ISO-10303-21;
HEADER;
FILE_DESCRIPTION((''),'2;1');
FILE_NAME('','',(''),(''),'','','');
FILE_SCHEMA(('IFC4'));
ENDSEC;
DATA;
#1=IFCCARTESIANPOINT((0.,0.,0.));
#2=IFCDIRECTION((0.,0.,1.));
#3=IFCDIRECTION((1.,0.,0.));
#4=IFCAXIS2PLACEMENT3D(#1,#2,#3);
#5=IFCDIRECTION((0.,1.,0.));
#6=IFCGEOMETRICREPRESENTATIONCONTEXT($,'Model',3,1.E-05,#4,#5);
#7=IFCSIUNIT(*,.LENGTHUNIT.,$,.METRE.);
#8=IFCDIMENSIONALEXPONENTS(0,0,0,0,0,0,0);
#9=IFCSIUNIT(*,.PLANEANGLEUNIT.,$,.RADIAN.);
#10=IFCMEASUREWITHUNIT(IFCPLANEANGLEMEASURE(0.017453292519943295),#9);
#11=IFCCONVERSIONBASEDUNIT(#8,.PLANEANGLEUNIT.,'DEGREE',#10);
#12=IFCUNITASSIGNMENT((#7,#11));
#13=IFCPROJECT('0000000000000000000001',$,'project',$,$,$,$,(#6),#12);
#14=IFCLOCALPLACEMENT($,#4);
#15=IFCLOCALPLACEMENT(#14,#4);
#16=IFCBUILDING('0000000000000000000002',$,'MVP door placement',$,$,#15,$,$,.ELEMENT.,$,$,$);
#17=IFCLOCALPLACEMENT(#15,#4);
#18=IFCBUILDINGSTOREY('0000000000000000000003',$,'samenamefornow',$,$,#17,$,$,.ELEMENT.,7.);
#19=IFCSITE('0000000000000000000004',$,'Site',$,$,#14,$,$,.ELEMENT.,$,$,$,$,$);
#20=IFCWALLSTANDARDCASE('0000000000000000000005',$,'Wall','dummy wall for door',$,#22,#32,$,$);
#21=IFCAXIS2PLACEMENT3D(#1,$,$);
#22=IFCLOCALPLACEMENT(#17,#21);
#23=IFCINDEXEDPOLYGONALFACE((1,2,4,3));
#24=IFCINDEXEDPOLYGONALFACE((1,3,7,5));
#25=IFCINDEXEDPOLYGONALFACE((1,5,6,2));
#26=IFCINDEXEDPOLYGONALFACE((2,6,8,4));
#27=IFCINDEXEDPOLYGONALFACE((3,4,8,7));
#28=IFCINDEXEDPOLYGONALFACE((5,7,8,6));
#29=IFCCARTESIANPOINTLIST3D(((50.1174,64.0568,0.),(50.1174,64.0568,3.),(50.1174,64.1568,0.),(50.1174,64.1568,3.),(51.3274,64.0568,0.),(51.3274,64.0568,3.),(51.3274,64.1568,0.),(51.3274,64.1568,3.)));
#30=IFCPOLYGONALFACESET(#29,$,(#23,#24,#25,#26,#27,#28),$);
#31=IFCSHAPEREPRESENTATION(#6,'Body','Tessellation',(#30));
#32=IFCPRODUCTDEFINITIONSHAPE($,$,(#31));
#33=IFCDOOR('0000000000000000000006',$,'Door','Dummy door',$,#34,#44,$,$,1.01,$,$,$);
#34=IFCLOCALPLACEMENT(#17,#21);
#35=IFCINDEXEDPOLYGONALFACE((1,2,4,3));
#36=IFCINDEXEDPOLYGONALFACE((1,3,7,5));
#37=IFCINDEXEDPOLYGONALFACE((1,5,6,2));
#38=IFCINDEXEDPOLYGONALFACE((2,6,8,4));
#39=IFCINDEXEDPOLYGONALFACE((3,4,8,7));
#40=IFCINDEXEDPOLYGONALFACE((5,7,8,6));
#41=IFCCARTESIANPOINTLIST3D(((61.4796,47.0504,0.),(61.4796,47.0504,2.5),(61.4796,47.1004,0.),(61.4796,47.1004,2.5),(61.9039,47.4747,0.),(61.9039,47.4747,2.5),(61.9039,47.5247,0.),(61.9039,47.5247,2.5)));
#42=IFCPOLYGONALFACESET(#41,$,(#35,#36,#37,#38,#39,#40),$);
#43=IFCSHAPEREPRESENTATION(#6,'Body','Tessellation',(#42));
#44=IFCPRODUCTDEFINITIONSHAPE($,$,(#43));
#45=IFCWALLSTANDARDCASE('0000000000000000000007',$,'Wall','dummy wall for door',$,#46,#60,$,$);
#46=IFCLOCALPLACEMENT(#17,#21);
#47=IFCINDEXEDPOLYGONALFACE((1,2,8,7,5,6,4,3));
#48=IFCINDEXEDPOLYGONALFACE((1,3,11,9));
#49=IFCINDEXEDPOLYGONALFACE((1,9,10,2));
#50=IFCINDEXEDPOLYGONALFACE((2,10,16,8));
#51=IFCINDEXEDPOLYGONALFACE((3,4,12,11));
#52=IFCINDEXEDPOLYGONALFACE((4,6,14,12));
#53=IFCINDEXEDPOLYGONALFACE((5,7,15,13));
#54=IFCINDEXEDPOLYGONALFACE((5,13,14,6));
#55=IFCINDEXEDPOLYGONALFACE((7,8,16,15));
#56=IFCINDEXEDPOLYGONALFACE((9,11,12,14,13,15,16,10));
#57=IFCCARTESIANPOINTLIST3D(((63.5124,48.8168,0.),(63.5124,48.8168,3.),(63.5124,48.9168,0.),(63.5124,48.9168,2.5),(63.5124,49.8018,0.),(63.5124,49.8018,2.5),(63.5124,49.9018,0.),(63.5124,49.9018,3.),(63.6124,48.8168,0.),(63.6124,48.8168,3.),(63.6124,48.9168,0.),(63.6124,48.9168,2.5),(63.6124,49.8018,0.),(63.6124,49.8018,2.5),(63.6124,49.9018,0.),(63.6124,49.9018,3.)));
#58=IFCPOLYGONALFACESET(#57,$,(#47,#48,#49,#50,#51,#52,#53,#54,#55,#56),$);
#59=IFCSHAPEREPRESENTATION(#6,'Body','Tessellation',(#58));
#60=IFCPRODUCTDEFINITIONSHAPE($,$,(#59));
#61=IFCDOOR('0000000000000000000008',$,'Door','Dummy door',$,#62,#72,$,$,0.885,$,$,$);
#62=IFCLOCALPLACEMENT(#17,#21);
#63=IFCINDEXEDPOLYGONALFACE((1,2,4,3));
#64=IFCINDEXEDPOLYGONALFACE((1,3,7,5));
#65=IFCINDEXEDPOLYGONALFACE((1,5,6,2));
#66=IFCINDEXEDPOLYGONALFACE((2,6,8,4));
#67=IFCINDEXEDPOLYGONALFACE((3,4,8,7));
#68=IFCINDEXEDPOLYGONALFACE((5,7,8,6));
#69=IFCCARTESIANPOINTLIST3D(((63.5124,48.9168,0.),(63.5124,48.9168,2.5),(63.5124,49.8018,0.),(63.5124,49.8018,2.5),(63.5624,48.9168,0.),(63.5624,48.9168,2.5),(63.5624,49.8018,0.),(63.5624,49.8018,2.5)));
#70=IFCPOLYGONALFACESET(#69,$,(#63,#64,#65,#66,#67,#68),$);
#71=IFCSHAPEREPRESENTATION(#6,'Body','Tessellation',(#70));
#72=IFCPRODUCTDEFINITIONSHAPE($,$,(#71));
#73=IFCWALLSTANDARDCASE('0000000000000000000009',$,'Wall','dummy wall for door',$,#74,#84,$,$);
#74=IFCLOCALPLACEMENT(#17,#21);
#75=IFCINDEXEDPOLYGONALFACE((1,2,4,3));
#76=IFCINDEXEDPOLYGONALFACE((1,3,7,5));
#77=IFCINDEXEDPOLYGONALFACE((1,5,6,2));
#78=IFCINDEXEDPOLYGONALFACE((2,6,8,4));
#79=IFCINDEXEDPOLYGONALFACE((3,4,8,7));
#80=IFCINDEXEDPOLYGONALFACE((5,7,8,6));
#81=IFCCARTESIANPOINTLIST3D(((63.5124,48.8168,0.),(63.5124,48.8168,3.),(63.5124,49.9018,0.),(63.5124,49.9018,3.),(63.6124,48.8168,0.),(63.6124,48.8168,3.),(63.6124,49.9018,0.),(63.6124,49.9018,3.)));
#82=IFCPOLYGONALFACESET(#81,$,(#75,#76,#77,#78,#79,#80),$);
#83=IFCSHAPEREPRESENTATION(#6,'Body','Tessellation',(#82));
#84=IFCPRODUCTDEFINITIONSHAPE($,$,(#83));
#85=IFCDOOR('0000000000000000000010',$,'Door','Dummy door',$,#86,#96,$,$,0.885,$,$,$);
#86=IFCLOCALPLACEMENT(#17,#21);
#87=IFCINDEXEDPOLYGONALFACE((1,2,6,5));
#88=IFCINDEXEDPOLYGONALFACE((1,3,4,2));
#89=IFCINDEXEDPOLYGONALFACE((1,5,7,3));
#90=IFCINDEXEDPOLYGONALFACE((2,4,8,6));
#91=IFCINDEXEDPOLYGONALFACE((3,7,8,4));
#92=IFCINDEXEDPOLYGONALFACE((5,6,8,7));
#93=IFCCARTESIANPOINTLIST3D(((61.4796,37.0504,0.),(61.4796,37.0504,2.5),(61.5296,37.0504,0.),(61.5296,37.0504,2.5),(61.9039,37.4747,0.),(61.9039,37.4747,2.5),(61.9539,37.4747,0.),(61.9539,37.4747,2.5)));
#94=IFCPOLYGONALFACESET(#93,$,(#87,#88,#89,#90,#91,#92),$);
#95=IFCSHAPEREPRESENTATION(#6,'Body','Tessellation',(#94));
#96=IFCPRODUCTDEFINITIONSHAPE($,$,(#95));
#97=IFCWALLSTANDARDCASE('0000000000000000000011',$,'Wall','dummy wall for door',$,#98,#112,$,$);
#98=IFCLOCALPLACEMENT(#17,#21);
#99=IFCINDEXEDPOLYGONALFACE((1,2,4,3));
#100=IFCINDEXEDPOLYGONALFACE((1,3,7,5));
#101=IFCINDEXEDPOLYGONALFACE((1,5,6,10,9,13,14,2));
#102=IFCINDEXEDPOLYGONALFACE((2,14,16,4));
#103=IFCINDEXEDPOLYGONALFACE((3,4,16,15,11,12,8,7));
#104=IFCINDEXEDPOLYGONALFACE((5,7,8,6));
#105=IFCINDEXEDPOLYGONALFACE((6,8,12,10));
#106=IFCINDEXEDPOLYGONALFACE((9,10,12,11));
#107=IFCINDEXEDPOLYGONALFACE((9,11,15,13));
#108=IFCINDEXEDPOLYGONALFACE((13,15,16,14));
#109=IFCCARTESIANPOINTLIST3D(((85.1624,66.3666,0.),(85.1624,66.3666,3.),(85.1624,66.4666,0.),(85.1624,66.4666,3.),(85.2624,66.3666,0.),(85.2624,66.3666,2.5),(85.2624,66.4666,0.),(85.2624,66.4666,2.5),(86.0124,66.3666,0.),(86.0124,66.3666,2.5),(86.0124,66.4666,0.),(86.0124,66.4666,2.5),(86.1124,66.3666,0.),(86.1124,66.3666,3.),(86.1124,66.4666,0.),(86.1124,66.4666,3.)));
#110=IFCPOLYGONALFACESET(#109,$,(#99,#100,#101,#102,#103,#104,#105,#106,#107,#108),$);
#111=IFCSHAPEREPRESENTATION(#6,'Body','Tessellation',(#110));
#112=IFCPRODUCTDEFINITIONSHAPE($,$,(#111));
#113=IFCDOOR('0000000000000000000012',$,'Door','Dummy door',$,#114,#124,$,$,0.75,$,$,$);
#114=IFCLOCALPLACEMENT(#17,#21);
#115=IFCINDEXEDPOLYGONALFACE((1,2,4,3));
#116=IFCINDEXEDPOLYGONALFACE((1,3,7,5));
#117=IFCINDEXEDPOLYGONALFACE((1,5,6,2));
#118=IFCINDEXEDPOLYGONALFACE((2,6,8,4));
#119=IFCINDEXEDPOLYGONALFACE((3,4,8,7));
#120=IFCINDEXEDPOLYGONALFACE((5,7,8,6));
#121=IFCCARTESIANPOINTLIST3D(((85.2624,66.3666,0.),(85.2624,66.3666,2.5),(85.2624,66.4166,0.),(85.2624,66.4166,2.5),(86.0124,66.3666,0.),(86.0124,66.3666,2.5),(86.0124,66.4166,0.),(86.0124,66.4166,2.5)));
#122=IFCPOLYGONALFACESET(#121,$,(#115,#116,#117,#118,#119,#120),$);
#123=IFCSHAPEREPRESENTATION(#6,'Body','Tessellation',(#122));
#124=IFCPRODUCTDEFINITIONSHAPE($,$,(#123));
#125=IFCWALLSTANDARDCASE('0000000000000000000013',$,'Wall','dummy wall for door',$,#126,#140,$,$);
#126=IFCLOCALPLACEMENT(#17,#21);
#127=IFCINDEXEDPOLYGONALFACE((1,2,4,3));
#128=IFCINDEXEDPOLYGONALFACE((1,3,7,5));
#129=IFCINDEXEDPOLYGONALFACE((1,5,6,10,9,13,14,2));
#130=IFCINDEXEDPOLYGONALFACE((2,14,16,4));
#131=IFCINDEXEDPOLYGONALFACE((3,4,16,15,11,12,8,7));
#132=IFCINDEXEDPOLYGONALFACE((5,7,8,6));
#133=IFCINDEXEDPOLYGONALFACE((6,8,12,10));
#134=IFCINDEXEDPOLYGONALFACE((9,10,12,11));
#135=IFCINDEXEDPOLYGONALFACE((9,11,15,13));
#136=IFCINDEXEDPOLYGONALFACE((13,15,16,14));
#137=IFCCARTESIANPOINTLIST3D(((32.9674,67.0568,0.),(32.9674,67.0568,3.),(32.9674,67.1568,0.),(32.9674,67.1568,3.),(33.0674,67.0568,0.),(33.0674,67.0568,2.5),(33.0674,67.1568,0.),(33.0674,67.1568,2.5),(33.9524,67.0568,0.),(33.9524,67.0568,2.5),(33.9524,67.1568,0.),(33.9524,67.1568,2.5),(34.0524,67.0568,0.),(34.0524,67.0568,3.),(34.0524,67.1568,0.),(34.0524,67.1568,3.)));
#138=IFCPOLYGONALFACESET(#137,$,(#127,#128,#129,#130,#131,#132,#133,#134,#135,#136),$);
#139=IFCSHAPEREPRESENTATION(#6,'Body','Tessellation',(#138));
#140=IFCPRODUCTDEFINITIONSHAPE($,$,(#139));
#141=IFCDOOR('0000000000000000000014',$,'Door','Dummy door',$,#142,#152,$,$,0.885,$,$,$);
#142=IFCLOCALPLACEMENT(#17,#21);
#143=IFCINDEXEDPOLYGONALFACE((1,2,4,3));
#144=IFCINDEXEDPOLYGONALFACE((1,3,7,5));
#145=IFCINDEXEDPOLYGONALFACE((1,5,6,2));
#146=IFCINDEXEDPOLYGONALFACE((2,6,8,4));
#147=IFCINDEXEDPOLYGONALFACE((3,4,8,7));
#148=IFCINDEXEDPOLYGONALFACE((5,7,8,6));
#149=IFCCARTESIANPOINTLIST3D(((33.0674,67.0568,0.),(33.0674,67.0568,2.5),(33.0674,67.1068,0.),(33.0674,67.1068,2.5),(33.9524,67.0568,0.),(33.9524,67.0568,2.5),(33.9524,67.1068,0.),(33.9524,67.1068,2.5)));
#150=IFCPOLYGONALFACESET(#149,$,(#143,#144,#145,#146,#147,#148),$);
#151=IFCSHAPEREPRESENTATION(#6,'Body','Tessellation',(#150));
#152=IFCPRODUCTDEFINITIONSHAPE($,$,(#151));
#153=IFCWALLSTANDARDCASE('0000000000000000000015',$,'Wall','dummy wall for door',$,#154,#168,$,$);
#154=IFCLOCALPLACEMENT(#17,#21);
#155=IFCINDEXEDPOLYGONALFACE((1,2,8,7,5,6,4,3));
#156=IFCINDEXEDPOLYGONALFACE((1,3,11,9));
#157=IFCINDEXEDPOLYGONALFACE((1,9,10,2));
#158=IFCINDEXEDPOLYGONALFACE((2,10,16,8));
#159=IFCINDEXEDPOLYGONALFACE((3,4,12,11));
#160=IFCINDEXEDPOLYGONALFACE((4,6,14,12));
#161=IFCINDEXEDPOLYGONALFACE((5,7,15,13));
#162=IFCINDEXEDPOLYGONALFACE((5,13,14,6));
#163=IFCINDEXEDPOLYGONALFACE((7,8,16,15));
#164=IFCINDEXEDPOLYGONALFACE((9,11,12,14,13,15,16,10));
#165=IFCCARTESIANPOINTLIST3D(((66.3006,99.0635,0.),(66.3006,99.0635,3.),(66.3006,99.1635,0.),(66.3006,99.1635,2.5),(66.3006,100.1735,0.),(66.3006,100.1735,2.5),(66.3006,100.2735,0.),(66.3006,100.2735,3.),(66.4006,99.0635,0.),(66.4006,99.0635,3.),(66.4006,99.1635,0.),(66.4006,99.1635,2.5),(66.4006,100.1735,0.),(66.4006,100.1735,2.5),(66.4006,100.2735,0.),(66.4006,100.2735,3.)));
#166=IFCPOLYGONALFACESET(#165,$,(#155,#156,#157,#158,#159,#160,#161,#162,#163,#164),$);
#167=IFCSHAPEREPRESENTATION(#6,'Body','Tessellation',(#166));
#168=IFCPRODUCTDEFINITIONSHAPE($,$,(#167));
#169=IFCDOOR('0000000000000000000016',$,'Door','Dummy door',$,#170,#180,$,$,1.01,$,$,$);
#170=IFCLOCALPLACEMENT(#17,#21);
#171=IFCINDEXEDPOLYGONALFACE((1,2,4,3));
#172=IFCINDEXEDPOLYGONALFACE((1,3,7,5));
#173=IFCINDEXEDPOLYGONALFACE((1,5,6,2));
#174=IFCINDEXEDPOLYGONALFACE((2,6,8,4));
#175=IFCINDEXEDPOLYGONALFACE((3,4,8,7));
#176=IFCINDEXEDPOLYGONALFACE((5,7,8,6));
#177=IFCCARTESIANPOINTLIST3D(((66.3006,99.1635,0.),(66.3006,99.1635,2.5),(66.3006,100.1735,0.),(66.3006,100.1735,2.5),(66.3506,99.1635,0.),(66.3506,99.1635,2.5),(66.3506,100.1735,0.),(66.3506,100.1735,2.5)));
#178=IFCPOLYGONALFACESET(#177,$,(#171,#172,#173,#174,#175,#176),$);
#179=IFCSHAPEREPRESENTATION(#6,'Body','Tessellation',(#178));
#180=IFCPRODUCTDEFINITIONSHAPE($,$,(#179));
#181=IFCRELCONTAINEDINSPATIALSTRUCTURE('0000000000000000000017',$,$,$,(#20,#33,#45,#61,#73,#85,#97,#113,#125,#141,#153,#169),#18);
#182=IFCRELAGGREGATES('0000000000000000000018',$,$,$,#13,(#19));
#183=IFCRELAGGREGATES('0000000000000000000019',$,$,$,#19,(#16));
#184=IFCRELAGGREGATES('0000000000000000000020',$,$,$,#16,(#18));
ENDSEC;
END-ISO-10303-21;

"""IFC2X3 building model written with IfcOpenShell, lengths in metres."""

from ifc_helpers import new_model, entity, si_unit, converted_unit, direction, origin_with_axes, place, context, project, spatial, polyline, outline, extrude, element, fill, save


model = new_model("IFC2X3")

# Units and contexts
model_context = context("Model", 3, precision=1e-05, world=origin_with_axes(), true_north=direction((0.0, 1.0, 0.0)))
ifc_project = project(units=[si_unit("LENGTHUNIT", "METRE"), converted_unit("PLANEANGLEUNIT", "DEGREE", entity("IfcPlaneAngleMeasure", 0.017453292519943295), si_unit("PLANEANGLEUNIT", "RADIAN"), dimensions=[0, 0, 0, 0, 0, 0, 0])], contexts=[model_context])

# Site, building, storey
site_placement = place(None, origin_with_axes())
site = spatial("IfcSite", under=ifc_project, at=site_placement, Name="Site", CompositionType="ELEMENT")
building_placement = place(site_placement, origin_with_axes())
building = spatial("IfcBuilding", under=site, at=building_placement, Name="MVP door placement", CompositionType="ELEMENT")
storey_placement = place(building_placement, origin_with_axes())
storey = spatial("IfcBuildingStorey", under=building, at=storey_placement, Name="samenamefornow", CompositionType="ELEMENT", Elevation=7.0)

# Walls, openings, doors
wall_1_placement = place(storey_placement, origin_with_axes())
wall_1 = element("IfcWallStandardCase", 1, at=wall_1_placement, inside=storey, Name="Wall", Description="dummy wall for door", context=model_context, shape_type="SweptSolid", body=[
    extrude(outline(polyline([(51.3274, 64.0568, 0.0), (50.1174, 64.0568, 0.0), (50.1174, 64.1568, 0.0), (51.3274, 64.1568, 0.0), (51.3274, 64.0568, 0.0)])), origin_with_axes(), (0.0, 0.0, 1.0), 3.0),
])
opening_1_placement = place(wall_1_placement, origin_with_axes())
opening_1 = element("IfcOpeningElement", 2, at=opening_1_placement, cuts=wall_1, context=model_context, shape_type="SweptSolid", body=[
    extrude(outline(polyline([(61.4796, 47.0504, 0.0), (61.9039, 47.4747, 0.0), (61.9039, 47.5747, 0.0), (61.4796, 47.1504, 0.0), (61.4796, 47.0504, 0.0)])), origin_with_axes(), (0.0, 0.0, 1.0), 2.5),
])
door_1_placement = place(opening_1_placement, origin_with_axes())
door_1 = element("IfcDoor", 3, at=door_1_placement, inside=storey, Name="Door", Description="Dummy door", OverallWidth=1.01, context=model_context, shape_type="SweptSolid", body=[
    extrude(outline(polyline([(61.4796, 47.0504, 0.0), (61.9039, 47.4747, 0.0), (61.9039, 47.5247, 0.0), (61.4796, 47.1004, 0.0), (61.4796, 47.0504, 0.0)])), origin_with_axes(), (0.0, 0.0, 1.0), 2.5),
])
fill(opening_1, door_1)
wall_2_placement = place(storey_placement, origin_with_axes())
wall_2 = element("IfcWallStandardCase", 4, at=wall_2_placement, inside=storey, Name="Wall", Description="dummy wall for door", context=model_context, shape_type="SweptSolid", body=[
    extrude(outline(polyline([(63.5124, 49.9018, 0.0), (63.5124, 48.8168, 0.0), (63.6124, 48.8168, 0.0), (63.6124, 49.9018, 0.0), (63.5124, 49.9018, 0.0)])), origin_with_axes(), (0.0, 0.0, 1.0), 3.0),
])
opening_2_placement = place(wall_2_placement, origin_with_axes())
opening_2 = element("IfcOpeningElement", 5, at=opening_2_placement, cuts=wall_2, context=model_context, shape_type="SweptSolid", body=[
    extrude(outline(polyline([(63.5124, 49.8018, 0.0), (63.5124, 48.9168, 0.0), (63.6124, 48.9168, 0.0), (63.6124, 49.8018, 0.0), (63.5124, 49.8018, 0.0)])), origin_with_axes(), (0.0, 0.0, 1.0), 2.5),
])
door_2_placement = place(opening_2_placement, origin_with_axes())
door_2 = element("IfcDoor", 6, at=door_2_placement, inside=storey, Name="Door", Description="Dummy door", OverallWidth=0.885, context=model_context, shape_type="SweptSolid", body=[
    extrude(outline(polyline([(63.5124, 49.8018, 0.0), (63.5124, 48.9168, 0.0), (63.5624, 48.9168, 0.0), (63.5624, 49.8018, 0.0), (63.5124, 49.8018, 0.0)])), origin_with_axes(), (0.0, 0.0, 1.0), 2.5),
])
fill(opening_2, door_2)
wall_3_placement = place(storey_placement, origin_with_axes())
wall_3 = element("IfcWallStandardCase", 7, at=wall_3_placement, inside=storey, Name="Wall", Description="dummy wall for door", context=model_context, shape_type="SweptSolid", body=[
    extrude(outline(polyline([(63.5124, 49.9018, 0.0), (63.5124, 48.8168, 0.0), (63.6124, 48.8168, 0.0), (63.6124, 49.9018, 0.0), (63.5124, 49.9018, 0.0)])), origin_with_axes(), (0.0, 0.0, 1.0), 3.0),
])
opening_3_placement = place(wall_3_placement, origin_with_axes())
opening_3 = element("IfcOpeningElement", 8, at=opening_3_placement, cuts=wall_3, context=model_context, shape_type="SweptSolid", body=[
    extrude(outline(polyline([(61.4796, 37.0504, 0.0), (61.9039, 37.4747, 0.0), (62.0039, 37.4747, 0.0), (61.5796, 37.0504, 0.0), (61.4796, 37.0504, 0.0)])), origin_with_axes(), (0.0, 0.0, 1.0), 2.5),
])
door_3_placement = place(opening_3_placement, origin_with_axes())
door_3 = element("IfcDoor", 9, at=door_3_placement, inside=storey, Name="Door", Description="Dummy door", OverallWidth=0.885, context=model_context, shape_type="SweptSolid", body=[
    extrude(outline(polyline([(61.4796, 37.0504, 0.0), (61.9039, 37.4747, 0.0), (61.9539, 37.4747, 0.0), (61.5296, 37.0504, 0.0), (61.4796, 37.0504, 0.0)])), origin_with_axes(), (0.0, 0.0, 1.0), 2.5),
])
fill(opening_3, door_3)
wall_4_placement = place(storey_placement, origin_with_axes())
wall_4 = element("IfcWallStandardCase", 10, at=wall_4_placement, inside=storey, Name="Wall", Description="dummy wall for door", context=model_context, shape_type="SweptSolid", body=[
    extrude(outline(polyline([(85.1624, 66.3666, 0.0), (86.1124, 66.3666, 0.0), (86.1124, 66.4666, 0.0), (85.1624, 66.4666, 0.0), (85.1624, 66.3666, 0.0)])), origin_with_axes(), (0.0, 0.0, 1.0), 3.0),
])
opening_4_placement = place(wall_4_placement, origin_with_axes())
opening_4 = element("IfcOpeningElement", 11, at=opening_4_placement, cuts=wall_4, context=model_context, shape_type="SweptSolid", body=[
    extrude(outline(polyline([(85.2624, 66.3666, 0.0), (86.0124, 66.3666, 0.0), (86.0124, 66.4666, 0.0), (85.2624, 66.4666, 0.0), (85.2624, 66.3666, 0.0)])), origin_with_axes(), (0.0, 0.0, 1.0), 2.5),
])
door_4_placement = place(opening_4_placement, origin_with_axes())
door_4 = element("IfcDoor", 12, at=door_4_placement, inside=storey, Name="Door", Description="Dummy door", OverallWidth=0.75, context=model_context, shape_type="SweptSolid", body=[
    extrude(outline(polyline([(85.2624, 66.3666, 0.0), (86.0124, 66.3666, 0.0), (86.0124, 66.4166, 0.0), (85.2624, 66.4166, 0.0), (85.2624, 66.3666, 0.0)])), origin_with_axes(), (0.0, 0.0, 1.0), 2.5),
])
fill(opening_4, door_4)
wall_5_placement = place(storey_placement, origin_with_axes())
wall_5 = element("IfcWallStandardCase", 13, at=wall_5_placement, inside=storey, Name="Wall", Description="dummy wall for door", context=model_context, shape_type="SweptSolid", body=[
    extrude(outline(polyline([(32.9674, 67.0568, 0.0), (34.0524, 67.0568, 0.0), (34.0524, 67.1568, 0.0), (32.9674, 67.1568, 0.0), (32.9674, 67.0568, 0.0)])), origin_with_axes(), (0.0, 0.0, 1.0), 3.0),
])
opening_5_placement = place(wall_5_placement, origin_with_axes())
opening_5 = element("IfcOpeningElement", 14, at=opening_5_placement, cuts=wall_5, context=model_context, shape_type="SweptSolid", body=[
    extrude(outline(polyline([(33.0674, 67.0568, 0.0), (33.9524, 67.0568, 0.0), (33.9524, 67.1568, 0.0), (33.0674, 67.1568, 0.0), (33.0674, 67.0568, 0.0)])), origin_with_axes(), (0.0, 0.0, 1.0), 2.5),
])
door_5_placement = place(opening_5_placement, origin_with_axes())
door_5 = element("IfcDoor", 15, at=door_5_placement, inside=storey, Name="Door", Description="Dummy door", OverallWidth=0.885, context=model_context, shape_type="SweptSolid", body=[
    extrude(outline(polyline([(33.0674, 67.0568, 0.0), (33.9524, 67.0568, 0.0), (33.9524, 67.1068, 0.0), (33.0674, 67.1068, 0.0), (33.0674, 67.0568, 0.0)])), origin_with_axes(), (0.0, 0.0, 1.0), 2.5),
])
fill(opening_5, door_5)
wall_6_placement = place(storey_placement, origin_with_axes())
wall_6 = element("IfcWallStandardCase", 16, at=wall_6_placement, inside=storey, Name="Wall", Description="dummy wall for door", context=model_context, shape_type="SweptSolid", body=[
    extrude(outline(polyline([(66.3006, 100.2735, 0.0), (66.3006, 99.0635, 0.0), (66.4006, 99.0635, 0.0), (66.4006, 100.2735, 0.0), (66.3006, 100.2735, 0.0)])), origin_with_axes(), (0.0, 0.0, 1.0), 3.0),
])
opening_6_placement = place(wall_6_placement, origin_with_axes())
opening_6 = element("IfcOpeningElement", 17, at=opening_6_placement, cuts=wall_6, context=model_context, shape_type="SweptSolid", body=[
    extrude(outline(polyline([(66.3006, 100.1735, 0.0), (66.3006, 99.1635, 0.0), (66.4006, 99.1635, 0.0), (66.4006, 100.1735, 0.0), (66.3006, 100.1735, 0.0)])), origin_with_axes(), (0.0, 0.0, 1.0), 2.5),
])
door_6_placement = place(opening_6_placement, origin_with_axes())
door_6 = element("IfcDoor", 18, at=door_6_placement, inside=storey, Name="Door", Description="Dummy door", OverallWidth=1.01, context=model_context, shape_type="SweptSolid", body=[
    extrude(outline(polyline([(66.3006, 100.1735, 0.0), (66.3006, 99.1635, 0.0), (66.3506, 99.1635, 0.0), (66.3506, 100.1735, 0.0), (66.3006, 100.1735, 0.0)])), origin_with_axes(), (0.0, 0.0, 1.0), 2.5),
])
fill(opening_6, door_6)

save(model, "model.ifc")
